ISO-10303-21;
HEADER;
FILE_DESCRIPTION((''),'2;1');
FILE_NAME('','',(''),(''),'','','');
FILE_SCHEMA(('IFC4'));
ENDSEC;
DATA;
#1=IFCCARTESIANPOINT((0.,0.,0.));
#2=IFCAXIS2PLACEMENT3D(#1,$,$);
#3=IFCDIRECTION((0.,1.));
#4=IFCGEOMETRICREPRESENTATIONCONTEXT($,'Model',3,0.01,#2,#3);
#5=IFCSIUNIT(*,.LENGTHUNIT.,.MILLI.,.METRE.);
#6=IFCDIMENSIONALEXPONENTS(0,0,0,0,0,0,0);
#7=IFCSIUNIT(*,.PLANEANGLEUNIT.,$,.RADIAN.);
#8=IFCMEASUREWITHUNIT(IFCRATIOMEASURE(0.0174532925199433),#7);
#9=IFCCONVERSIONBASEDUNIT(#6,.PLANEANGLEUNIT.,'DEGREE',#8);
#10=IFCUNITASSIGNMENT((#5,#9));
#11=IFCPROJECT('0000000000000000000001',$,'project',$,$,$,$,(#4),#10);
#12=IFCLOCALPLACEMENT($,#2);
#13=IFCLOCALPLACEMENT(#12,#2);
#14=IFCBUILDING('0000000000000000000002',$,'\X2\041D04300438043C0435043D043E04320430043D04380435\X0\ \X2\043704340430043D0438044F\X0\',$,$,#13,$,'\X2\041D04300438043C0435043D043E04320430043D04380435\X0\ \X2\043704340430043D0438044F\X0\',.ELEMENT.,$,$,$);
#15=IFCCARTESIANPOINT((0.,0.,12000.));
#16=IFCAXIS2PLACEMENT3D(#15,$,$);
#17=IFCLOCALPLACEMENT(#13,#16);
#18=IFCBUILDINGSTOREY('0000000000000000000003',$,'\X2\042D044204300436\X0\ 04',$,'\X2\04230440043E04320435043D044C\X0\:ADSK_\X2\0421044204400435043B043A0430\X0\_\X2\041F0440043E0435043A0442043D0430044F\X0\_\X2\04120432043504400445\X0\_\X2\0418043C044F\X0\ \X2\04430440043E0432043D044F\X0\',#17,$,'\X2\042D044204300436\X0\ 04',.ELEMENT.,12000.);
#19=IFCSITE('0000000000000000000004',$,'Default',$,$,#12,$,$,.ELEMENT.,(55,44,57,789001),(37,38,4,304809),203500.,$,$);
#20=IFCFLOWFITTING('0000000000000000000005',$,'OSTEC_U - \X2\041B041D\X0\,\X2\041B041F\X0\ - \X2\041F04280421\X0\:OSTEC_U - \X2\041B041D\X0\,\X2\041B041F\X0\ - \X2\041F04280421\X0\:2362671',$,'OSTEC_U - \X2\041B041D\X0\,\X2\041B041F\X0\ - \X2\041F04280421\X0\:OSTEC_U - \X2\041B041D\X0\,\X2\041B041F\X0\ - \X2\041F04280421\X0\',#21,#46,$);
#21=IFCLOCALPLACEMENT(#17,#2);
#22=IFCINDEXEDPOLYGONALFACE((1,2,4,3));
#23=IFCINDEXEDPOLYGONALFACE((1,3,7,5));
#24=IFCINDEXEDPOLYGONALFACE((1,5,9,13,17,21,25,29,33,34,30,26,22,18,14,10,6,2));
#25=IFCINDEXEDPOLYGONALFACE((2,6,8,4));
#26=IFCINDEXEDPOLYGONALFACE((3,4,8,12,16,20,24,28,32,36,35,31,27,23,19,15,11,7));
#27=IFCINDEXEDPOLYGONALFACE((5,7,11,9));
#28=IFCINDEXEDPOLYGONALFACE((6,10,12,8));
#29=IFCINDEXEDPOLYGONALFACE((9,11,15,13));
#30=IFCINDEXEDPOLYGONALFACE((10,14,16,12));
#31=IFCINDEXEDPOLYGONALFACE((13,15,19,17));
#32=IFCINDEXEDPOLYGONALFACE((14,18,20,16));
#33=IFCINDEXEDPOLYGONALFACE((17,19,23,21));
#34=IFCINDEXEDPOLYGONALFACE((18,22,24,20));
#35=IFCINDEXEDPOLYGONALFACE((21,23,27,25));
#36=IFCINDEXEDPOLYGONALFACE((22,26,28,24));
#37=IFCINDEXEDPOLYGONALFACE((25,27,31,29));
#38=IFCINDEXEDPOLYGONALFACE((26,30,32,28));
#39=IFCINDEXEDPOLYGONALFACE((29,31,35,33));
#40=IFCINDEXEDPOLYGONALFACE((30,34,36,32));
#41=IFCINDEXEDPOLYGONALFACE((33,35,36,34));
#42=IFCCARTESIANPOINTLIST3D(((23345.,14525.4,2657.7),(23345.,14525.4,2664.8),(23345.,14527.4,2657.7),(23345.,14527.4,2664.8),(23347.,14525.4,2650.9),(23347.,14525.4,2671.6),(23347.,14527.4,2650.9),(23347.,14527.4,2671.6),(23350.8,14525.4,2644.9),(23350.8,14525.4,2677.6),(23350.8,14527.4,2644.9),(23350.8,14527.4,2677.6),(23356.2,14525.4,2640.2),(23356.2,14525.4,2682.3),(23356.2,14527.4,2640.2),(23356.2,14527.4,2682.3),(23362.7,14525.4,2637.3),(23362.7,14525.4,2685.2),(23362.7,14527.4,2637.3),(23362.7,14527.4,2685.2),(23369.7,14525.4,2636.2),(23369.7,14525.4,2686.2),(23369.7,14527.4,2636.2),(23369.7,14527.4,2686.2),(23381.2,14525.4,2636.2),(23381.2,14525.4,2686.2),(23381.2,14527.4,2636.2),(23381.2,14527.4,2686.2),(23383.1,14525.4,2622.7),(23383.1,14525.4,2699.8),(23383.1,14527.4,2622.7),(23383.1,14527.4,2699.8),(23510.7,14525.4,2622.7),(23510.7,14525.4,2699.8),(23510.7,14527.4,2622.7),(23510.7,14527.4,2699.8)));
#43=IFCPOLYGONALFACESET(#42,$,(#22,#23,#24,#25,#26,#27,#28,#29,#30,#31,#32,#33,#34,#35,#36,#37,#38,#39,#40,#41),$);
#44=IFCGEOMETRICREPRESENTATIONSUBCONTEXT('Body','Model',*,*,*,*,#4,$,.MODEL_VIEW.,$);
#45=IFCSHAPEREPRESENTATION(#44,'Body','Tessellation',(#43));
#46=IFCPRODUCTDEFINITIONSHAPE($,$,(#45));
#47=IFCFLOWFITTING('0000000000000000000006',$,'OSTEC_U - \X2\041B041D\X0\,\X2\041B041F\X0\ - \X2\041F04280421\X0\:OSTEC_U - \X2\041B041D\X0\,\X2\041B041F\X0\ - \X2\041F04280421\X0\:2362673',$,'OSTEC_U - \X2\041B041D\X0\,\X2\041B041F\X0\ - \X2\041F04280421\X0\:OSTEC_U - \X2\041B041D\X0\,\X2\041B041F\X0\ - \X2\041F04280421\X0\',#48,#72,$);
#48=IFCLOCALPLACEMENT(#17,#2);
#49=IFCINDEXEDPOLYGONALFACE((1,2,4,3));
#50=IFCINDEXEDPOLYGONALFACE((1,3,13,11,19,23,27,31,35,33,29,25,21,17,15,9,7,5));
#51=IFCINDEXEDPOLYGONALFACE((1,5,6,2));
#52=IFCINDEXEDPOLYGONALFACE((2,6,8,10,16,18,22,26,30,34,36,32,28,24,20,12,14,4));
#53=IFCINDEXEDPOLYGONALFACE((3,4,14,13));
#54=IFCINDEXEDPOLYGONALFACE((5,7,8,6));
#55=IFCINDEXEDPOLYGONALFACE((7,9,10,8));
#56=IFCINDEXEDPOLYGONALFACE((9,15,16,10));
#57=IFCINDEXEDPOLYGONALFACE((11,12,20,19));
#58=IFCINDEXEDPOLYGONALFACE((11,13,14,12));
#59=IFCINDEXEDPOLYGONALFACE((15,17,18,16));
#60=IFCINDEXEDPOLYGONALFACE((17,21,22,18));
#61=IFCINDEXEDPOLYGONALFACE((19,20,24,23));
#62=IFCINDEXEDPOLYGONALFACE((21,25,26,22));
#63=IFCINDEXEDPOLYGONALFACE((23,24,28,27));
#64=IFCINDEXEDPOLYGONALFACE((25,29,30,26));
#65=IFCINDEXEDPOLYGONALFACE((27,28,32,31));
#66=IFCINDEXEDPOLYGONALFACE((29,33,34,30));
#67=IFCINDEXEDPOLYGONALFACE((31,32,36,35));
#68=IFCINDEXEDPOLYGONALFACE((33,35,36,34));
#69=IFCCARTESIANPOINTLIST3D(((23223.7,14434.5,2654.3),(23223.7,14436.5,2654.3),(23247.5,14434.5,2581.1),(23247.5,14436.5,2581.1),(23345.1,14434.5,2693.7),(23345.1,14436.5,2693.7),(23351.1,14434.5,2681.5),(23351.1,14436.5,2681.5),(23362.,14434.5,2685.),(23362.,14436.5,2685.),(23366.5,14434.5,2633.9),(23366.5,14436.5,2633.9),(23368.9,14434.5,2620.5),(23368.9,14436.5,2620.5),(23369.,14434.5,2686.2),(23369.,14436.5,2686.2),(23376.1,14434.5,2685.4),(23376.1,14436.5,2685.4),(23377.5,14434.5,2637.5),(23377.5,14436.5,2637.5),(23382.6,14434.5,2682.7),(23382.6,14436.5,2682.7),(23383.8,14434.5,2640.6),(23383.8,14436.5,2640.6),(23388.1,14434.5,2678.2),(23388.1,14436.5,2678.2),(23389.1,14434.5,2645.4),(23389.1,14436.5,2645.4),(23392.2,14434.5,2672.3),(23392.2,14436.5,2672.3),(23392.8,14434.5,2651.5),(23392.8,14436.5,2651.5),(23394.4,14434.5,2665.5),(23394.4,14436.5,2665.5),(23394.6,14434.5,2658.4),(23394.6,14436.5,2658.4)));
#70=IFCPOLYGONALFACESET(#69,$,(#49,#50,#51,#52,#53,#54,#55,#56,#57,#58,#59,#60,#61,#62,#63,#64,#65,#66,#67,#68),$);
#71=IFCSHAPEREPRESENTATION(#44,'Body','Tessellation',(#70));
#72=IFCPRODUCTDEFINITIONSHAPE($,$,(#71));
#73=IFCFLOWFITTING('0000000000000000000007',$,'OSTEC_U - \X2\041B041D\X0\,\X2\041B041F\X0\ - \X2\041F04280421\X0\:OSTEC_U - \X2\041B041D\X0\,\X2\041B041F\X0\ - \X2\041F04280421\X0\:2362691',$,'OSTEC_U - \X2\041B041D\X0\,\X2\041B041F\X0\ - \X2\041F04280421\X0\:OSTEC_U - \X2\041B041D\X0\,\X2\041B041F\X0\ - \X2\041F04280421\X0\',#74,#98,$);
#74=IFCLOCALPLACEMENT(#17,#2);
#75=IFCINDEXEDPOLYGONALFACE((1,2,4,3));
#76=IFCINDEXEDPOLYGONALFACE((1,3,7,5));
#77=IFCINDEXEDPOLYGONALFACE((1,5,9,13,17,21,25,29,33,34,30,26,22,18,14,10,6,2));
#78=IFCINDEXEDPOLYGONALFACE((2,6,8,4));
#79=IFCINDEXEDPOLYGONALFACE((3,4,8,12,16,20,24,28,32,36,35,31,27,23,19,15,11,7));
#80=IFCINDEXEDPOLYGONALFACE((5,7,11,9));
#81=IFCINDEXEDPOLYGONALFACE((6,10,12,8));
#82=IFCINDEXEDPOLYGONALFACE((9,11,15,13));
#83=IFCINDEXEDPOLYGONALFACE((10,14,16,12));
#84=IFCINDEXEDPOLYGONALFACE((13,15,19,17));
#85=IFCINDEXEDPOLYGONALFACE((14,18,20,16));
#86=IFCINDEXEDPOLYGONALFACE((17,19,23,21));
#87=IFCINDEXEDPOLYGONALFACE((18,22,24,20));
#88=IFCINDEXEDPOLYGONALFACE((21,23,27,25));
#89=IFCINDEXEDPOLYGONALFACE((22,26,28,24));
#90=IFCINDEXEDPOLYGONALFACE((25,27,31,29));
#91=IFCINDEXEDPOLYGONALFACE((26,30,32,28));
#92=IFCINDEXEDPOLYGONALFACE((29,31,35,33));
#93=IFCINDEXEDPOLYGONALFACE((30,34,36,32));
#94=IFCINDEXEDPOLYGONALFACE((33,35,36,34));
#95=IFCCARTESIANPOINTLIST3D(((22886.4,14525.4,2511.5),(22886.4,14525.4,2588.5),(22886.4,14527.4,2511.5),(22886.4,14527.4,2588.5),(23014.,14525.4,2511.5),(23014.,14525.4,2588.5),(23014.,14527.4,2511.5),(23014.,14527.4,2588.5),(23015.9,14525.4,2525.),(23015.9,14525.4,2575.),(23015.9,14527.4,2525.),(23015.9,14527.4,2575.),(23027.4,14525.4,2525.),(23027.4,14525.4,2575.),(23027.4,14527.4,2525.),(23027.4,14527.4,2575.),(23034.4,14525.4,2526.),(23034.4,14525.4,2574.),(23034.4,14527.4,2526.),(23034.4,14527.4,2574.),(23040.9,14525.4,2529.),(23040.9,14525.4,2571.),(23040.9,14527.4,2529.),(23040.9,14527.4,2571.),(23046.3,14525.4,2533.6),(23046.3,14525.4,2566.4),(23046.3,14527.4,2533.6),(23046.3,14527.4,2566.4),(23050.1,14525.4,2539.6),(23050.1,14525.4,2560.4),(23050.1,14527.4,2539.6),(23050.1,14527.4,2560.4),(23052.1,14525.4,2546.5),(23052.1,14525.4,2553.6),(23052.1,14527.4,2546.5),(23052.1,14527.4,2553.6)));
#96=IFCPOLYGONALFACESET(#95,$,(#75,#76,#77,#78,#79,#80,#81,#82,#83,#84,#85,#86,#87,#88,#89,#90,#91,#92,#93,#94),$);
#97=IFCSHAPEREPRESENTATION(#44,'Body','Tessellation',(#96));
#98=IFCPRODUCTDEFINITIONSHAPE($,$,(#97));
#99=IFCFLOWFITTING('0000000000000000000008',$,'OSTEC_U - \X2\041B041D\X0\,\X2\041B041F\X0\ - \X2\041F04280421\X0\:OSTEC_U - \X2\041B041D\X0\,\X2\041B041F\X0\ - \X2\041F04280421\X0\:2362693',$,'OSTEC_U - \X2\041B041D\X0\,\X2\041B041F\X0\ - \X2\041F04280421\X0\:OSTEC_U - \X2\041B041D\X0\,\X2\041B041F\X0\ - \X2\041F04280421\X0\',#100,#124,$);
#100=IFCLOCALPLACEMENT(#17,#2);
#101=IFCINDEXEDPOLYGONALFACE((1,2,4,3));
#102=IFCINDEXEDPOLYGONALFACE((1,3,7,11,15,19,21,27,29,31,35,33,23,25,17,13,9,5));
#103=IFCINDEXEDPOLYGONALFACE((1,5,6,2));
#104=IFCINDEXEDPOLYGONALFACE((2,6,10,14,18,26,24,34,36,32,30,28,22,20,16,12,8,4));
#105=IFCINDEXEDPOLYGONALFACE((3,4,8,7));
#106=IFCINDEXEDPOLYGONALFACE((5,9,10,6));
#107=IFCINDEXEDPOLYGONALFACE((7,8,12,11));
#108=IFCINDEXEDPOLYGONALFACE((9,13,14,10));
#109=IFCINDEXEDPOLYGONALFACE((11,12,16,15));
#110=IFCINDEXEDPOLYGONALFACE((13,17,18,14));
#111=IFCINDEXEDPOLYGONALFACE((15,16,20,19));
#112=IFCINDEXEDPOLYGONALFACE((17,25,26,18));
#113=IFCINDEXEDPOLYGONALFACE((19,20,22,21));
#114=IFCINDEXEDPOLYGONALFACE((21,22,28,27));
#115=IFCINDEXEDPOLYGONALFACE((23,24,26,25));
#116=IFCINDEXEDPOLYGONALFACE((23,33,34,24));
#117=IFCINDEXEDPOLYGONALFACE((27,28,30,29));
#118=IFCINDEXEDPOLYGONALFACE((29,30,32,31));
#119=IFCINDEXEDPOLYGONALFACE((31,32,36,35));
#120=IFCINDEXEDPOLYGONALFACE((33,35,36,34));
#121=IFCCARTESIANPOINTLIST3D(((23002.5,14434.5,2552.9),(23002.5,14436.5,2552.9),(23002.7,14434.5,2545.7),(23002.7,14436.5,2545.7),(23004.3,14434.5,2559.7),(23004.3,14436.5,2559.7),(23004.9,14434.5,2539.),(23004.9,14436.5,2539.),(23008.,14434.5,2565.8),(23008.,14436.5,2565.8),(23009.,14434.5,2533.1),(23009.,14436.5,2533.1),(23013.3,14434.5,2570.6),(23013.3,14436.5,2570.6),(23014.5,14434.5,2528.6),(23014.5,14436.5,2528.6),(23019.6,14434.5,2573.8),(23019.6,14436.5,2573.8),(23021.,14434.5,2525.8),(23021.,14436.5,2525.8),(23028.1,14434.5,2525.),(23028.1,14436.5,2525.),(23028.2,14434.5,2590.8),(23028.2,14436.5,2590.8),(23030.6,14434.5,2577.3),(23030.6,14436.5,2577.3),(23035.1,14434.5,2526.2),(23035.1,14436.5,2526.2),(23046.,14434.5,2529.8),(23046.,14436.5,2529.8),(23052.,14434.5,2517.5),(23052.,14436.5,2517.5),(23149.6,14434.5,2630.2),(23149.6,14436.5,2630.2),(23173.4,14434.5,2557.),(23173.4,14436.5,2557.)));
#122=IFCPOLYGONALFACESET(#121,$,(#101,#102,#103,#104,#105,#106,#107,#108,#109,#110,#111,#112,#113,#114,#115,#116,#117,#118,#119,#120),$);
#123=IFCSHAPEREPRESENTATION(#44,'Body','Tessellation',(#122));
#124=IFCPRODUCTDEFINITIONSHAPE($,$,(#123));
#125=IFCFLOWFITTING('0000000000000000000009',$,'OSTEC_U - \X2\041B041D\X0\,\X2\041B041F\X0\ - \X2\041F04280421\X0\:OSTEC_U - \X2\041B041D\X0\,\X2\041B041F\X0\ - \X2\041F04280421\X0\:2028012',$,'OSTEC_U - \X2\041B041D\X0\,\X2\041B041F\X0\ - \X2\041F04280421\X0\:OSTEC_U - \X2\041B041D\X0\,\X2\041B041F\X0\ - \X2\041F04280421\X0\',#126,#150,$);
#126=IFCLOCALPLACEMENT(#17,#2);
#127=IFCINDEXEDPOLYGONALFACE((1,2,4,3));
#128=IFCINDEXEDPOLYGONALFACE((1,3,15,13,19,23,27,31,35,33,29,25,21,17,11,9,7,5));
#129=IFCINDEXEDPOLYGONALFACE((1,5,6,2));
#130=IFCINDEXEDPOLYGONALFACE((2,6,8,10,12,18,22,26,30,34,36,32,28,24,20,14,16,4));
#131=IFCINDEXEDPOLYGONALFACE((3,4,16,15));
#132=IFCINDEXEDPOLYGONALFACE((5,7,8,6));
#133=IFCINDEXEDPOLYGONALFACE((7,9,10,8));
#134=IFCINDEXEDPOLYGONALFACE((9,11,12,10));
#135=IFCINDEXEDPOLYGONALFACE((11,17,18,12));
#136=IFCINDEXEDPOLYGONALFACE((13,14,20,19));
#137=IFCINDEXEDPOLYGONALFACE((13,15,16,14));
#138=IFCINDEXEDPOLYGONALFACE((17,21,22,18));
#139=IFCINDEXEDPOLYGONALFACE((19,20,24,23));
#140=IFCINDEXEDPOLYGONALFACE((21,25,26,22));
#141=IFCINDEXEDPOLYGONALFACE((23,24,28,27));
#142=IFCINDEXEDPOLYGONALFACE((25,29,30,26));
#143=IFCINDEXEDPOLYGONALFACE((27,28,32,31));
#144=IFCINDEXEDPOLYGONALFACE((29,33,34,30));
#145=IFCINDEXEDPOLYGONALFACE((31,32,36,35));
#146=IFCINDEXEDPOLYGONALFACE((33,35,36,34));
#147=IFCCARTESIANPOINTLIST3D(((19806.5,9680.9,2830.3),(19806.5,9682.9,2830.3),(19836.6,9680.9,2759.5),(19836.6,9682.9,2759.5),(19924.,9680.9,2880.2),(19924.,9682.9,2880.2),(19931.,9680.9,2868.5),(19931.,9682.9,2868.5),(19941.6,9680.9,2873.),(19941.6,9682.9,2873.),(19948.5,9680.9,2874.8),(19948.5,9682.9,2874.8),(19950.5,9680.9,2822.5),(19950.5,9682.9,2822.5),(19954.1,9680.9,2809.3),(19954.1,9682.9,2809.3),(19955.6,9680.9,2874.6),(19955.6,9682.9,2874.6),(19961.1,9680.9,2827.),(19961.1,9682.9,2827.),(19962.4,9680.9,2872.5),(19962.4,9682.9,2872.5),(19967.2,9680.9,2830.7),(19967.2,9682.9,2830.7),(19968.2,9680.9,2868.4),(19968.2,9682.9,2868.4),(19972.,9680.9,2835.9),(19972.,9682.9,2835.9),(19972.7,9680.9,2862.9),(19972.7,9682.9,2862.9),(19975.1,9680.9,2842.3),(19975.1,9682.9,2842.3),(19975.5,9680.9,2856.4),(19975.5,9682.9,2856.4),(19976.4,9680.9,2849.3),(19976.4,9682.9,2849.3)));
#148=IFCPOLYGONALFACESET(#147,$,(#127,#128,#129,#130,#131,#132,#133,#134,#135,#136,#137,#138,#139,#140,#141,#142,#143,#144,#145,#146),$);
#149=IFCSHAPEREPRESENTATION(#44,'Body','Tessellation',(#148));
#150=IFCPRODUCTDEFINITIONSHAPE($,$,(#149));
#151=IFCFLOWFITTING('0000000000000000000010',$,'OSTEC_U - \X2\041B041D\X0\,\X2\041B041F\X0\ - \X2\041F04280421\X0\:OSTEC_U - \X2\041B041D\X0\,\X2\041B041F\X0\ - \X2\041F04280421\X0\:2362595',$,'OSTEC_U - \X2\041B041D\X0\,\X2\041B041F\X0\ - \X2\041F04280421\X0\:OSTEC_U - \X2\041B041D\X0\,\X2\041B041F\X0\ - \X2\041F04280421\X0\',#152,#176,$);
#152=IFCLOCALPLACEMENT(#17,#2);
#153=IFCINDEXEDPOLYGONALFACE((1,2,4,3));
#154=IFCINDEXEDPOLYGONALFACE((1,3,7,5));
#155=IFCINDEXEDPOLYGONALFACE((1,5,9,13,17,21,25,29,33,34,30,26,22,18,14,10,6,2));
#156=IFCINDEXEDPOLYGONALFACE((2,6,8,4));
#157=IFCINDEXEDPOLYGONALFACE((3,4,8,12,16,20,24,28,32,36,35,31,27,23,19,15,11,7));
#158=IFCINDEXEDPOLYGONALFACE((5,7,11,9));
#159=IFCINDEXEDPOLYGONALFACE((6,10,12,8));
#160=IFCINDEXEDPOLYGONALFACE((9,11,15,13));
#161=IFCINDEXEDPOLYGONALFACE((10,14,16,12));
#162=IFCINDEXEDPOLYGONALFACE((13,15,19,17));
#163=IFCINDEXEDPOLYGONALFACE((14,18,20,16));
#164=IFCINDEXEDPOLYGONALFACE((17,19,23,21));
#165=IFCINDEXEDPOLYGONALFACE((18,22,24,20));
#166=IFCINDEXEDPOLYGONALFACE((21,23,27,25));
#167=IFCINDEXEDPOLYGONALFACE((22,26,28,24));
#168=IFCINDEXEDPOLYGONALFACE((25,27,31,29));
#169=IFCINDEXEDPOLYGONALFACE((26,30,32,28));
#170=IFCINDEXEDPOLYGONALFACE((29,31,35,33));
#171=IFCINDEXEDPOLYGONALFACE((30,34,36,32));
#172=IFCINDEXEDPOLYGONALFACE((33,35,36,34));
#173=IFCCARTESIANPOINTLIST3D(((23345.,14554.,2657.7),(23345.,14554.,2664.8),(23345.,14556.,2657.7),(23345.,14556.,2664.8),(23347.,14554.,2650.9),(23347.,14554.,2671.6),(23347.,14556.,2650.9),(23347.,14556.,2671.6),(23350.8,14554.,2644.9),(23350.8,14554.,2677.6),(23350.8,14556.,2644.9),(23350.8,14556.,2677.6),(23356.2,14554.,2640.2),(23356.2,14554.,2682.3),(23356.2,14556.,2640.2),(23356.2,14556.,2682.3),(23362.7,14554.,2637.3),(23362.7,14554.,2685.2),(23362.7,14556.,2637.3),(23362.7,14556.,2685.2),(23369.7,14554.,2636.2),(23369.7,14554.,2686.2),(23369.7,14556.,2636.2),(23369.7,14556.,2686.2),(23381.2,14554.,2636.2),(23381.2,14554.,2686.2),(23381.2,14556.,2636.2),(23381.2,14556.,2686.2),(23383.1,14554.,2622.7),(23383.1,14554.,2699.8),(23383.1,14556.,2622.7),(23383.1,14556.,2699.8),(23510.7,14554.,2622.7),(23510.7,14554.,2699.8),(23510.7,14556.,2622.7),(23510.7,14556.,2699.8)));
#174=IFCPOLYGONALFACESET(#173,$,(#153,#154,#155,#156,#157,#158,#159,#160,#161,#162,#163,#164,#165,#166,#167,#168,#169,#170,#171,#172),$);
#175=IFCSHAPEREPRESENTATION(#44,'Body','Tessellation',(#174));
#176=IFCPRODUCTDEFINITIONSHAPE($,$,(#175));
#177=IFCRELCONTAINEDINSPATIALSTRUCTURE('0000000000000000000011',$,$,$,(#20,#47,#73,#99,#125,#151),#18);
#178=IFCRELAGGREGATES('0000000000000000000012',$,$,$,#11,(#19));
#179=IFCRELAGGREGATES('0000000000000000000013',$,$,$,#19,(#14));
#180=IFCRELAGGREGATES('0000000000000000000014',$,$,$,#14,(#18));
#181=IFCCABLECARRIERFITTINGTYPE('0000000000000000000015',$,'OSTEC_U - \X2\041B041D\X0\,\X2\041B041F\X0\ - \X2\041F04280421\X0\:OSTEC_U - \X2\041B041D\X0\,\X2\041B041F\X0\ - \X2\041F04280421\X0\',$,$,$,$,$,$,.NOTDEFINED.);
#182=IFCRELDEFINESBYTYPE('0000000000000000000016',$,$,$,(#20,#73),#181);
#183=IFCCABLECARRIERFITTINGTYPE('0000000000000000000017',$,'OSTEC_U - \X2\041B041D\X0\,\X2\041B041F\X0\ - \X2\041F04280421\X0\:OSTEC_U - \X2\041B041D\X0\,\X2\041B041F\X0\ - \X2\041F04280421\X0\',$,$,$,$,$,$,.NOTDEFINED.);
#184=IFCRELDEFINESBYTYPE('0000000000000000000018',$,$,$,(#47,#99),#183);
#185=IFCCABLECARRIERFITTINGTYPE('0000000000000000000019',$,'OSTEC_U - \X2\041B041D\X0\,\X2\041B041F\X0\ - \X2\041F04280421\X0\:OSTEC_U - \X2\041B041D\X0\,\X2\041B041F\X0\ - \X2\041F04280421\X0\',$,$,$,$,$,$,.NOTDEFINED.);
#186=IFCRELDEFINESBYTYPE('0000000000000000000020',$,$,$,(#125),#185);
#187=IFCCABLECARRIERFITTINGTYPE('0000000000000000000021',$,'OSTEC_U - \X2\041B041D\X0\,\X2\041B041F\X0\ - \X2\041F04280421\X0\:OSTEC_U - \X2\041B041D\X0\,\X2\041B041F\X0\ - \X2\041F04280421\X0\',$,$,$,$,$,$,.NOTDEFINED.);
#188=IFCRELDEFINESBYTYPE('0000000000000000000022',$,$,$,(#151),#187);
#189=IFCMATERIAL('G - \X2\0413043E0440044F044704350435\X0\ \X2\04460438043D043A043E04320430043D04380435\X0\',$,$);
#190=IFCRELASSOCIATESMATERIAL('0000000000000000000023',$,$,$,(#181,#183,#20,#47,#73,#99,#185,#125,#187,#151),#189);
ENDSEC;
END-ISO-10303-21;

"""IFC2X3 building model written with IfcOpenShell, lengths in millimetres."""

from ifc_helpers import new_model, entity, si_unit, converted_unit, direction, frame, frame_2d, origin, place, context, subcontext, project, spatial, polyline, circle_curve, parameter, trimmed, segment, composite_curve, outline, extrude, source, transform, mapped, material, type_object, type_shapes, element, save


model = new_model("IFC2X3")

# Units and contexts
model_context = context("Model", 3, precision=0.01, world=origin(), true_north=direction((0.0, 1.0)))
body_context = subcontext(model_context, "Body", "Model", "MODEL_VIEW")
ifc_project = project(units=[si_unit("LENGTHUNIT", "METRE", prefix="MILLI"), converted_unit("PLANEANGLEUNIT", "DEGREE", entity("IfcRatioMeasure", 0.0174532925199433), si_unit("PLANEANGLEUNIT", "RADIAN"), dimensions=[0, 0, 0, 0, 0, 0, 0])], contexts=[model_context])

# Site, building, storey
site_placement = place(None, origin())
site = spatial("IfcSite", under=ifc_project, at=site_placement, Name="Default", CompositionType="ELEMENT", RefLatitude=(55, 44, 57, 789001), RefLongitude=(37, 38, 4, 304809), RefElevation=203500.0)
building_placement = place(site_placement, origin())
building = spatial("IfcBuilding", under=site, at=building_placement, Name="Наименование здания", LongName="Наименование здания", CompositionType="ELEMENT")
storey_placement = place(building_placement, frame((0.0, 0.0, 12000.0)))
storey = spatial("IfcBuildingStorey", under=building, at=storey_placement, Name="Этаж 04", ObjectType="Уровень:ADSK_Стрелка_Проектная_Вверх_Имя уровня", LongName="Этаж 04", CompositionType="ELEMENT", Elevation=12000.0)

# Flow fittings
ifc_material = material(Name="G - Горячее цинкование")
cable_carrier_fitting_type_1 = type_object("IfcCableCarrierFittingType", Name="OSTEC_U - ЛН,ЛП - ПШС:OSTEC_U - ЛН,ЛП - ПШС", PredefinedType="NOTDEFINED", material=ifc_material)
shared_shape_1 = source(origin(), body_context, "Body", "SweptSolid", [
    extrude(outline(composite_curve([segment(trimmed(circle_curve(frame_2d((-41.5, 0.0), x_axis=(1.0, 0.0)), 25.0), [parameter(90.0)], [parameter(270.0)], True, "PARAMETER"), True, "CONTINUOUS"), segment(polyline([(-41.5, -25.0), (-30.0, -25.0)]), True, "CONTINUOUS"), segment(polyline([(-30.0, -25.0), (-28.1, -38.5)]), True, "CONTINUOUS"), segment(polyline([(-28.1, -38.5), (99.5, -38.5)]), True, "CONTINUOUS"), segment(polyline([(99.5, -38.5), (99.5, 38.5)]), True, "CONTINUOUS"), segment(polyline([(99.5, 38.5), (-28.1, 38.5)]), True, "CONTINUOUS"), segment(polyline([(-28.1, 38.5), (-30.0, 25.0)]), True, "CONTINUOUS"), segment(polyline([(-30.0, 25.0), (-41.5, 25.0)]), True, "CONTINUOUS")], self_intersect=False)), frame((41.5, 0.0, 0.0), z_axis=(0.0, 0.0, -1.0), x_axis=(1.0, 0.0, 0.0)), (0.0, 0.0, -1.0), 2.0),
])
type_shapes(cable_carrier_fitting_type_1, [shared_shape_1])
cable_carrier_fitting_type_2 = type_object("IfcCableCarrierFittingType", Name="OSTEC_U - ЛН,ЛП - ПШС:OSTEC_U - ЛН,ЛП - ПШС", PredefinedType="NOTDEFINED", material=ifc_material)
type_shapes(cable_carrier_fitting_type_2, [shared_shape_1])
flow_fitting_1_placement = place(storey_placement, frame((23369.7, 14525.5, 2661.2), z_axis=(0.0, 1.0, 0.0), x_axis=(1.0, 0.0, 0.0)))
element("IfcFlowFitting", 1, at=flow_fitting_1_placement, inside=storey, type_object=cable_carrier_fitting_type_1, material=ifc_material, Name="OSTEC_U - ЛН,ЛП - ПШС:OSTEC_U - ЛН,ЛП - ПШС:2362671", ObjectType="OSTEC_U - ЛН,ЛП - ПШС:OSTEC_U - ЛН,ЛП - ПШС", context=body_context, shape_type="MappedRepresentation", body=[
    mapped(shared_shape_1, transform((0.0, 0.0, 0.0), scale=1.0)),
])
flow_fitting_2_placement = place(storey_placement, frame((23369.7, 14436.5, 2661.2), z_axis=(0.0, -1.0, 0.0), x_axis=(-0.951057, 0.0, -0.309017)))
element("IfcFlowFitting", 2, at=flow_fitting_2_placement, inside=storey, type_object=cable_carrier_fitting_type_2, material=ifc_material, Name="OSTEC_U - ЛН,ЛП - ПШС:OSTEC_U - ЛН,ЛП - ПШС:2362673", ObjectType="OSTEC_U - ЛН,ЛП - ПШС:OSTEC_U - ЛН,ЛП - ПШС", context=body_context, shape_type="MappedRepresentation", body=[
    mapped(shared_shape_1, transform((0.0, 0.0, 0.0), scale=1.0)),
])
flow_fitting_3_placement = place(storey_placement, frame((23027.4, 14525.5, 2550.0), z_axis=(0.0, 1.0, 0.0), x_axis=(-1.0, 0.0, -0.000002)))
element("IfcFlowFitting", 3, at=flow_fitting_3_placement, inside=storey, type_object=cable_carrier_fitting_type_1, material=ifc_material, Name="OSTEC_U - ЛН,ЛП - ПШС:OSTEC_U - ЛН,ЛП - ПШС:2362691", ObjectType="OSTEC_U - ЛН,ЛП - ПШС:OSTEC_U - ЛН,ЛП - ПШС", context=body_context, shape_type="MappedRepresentation", body=[
    mapped(shared_shape_1, transform((0.0, 0.0, 0.0), scale=1.0)),
])
flow_fitting_4_placement = place(storey_placement, frame((23027.4, 14436.5, 2550.0), z_axis=(0.0, -1.0, 0.0), x_axis=(0.951057, 0.0, 0.309017)))
element("IfcFlowFitting", 4, at=flow_fitting_4_placement, inside=storey, type_object=cable_carrier_fitting_type_2, material=ifc_material, Name="OSTEC_U - ЛН,ЛП - ПШС:OSTEC_U - ЛН,ЛП - ПШС:2362693", ObjectType="OSTEC_U - ЛН,ЛП - ПШС:OSTEC_U - ЛН,ЛП - ПШС", context=body_context, shape_type="MappedRepresentation", body=[
    mapped(shared_shape_1, transform((0.0, 0.0, 0.0), scale=1.0)),
])
cable_carrier_fitting_type_3 = type_object("IfcCableCarrierFittingType", Name="OSTEC_U - ЛН,ЛП - ПШС:OSTEC_U - ЛН,ЛП - ПШС", PredefinedType="NOTDEFINED", material=ifc_material)
shared_shape_2 = source(origin(), body_context, "Body", "SweptSolid", [
    extrude(outline(composite_curve([segment(trimmed(circle_curve(frame_2d((-41.5, 0.0), x_axis=(1.0, 0.0)), 25.0), [parameter(90.0)], [parameter(270.0)], True, "PARAMETER"), True, "CONTINUOUS"), segment(polyline([(-41.5, -25.0), (-30.0, -25.0)]), True, "CONTINUOUS"), segment(polyline([(-30.0, -25.0), (-28.1, -38.5)]), True, "CONTINUOUS"), segment(polyline([(-28.1, -38.5), (99.5, -38.5)]), True, "CONTINUOUS"), segment(polyline([(99.5, -38.5), (99.5, 38.5)]), True, "CONTINUOUS"), segment(polyline([(99.5, 38.5), (-28.1, 38.5)]), True, "CONTINUOUS"), segment(polyline([(-28.1, 38.5), (-30.0, 25.0)]), True, "CONTINUOUS"), segment(polyline([(-30.0, 25.0), (-41.5, 25.0)]), True, "CONTINUOUS")], self_intersect=False)), frame((41.5, 0.0, 0.0)), (0.0, 0.0, 1.0), 2.0),
])
type_shapes(cable_carrier_fitting_type_3, [shared_shape_2])
flow_fitting_5_placement = place(storey_placement, frame((19951.4, 9680.9, 2850.0), z_axis=(0.0, 1.0, 0.0), x_axis=(-0.920505, 0.0, -0.390731)))
element("IfcFlowFitting", 5, at=flow_fitting_5_placement, inside=storey, type_object=cable_carrier_fitting_type_3, material=ifc_material, Name="OSTEC_U - ЛН,ЛП - ПШС:OSTEC_U - ЛН,ЛП - ПШС:2028012", ObjectType="OSTEC_U - ЛН,ЛП - ПШС:OSTEC_U - ЛН,ЛП - ПШС", context=body_context, shape_type="MappedRepresentation", body=[
    mapped(shared_shape_2, transform((0.0, 0.0, 0.0), scale=1.0)),
])
cable_carrier_fitting_type_4 = type_object("IfcCableCarrierFittingType", Name="OSTEC_U - ЛН,ЛП - ПШС:OSTEC_U - ЛН,ЛП - ПШС", PredefinedType="NOTDEFINED", material=ifc_material)
type_shapes(cable_carrier_fitting_type_4, [shared_shape_2])
for number, where, z_axis, x_axis, name in (
    (6, (23369.7, 14556.0, 2661.2), (0.0, -1.0, 0.0), (1.0, 0.0, 0.0), "OSTEC_U - ЛН,ЛП - ПШС:OSTEC_U - ЛН,ЛП - ПШС:2362595"),
):
    element("IfcFlowFitting", number, at=place(storey_placement, frame(where, z_axis=z_axis, x_axis=x_axis)), inside=storey, type_object=cable_carrier_fitting_type_4, material=ifc_material, Name=name, ObjectType="OSTEC_U - ЛН,ЛП - ПШС:OSTEC_U - ЛН,ЛП - ПШС", context=body_context, shape_type="MappedRepresentation", body=[
        mapped(shared_shape_2, transform((0.0, 0.0, 0.0), scale=1.0)),
    ])

save(model, "model.ifc")
